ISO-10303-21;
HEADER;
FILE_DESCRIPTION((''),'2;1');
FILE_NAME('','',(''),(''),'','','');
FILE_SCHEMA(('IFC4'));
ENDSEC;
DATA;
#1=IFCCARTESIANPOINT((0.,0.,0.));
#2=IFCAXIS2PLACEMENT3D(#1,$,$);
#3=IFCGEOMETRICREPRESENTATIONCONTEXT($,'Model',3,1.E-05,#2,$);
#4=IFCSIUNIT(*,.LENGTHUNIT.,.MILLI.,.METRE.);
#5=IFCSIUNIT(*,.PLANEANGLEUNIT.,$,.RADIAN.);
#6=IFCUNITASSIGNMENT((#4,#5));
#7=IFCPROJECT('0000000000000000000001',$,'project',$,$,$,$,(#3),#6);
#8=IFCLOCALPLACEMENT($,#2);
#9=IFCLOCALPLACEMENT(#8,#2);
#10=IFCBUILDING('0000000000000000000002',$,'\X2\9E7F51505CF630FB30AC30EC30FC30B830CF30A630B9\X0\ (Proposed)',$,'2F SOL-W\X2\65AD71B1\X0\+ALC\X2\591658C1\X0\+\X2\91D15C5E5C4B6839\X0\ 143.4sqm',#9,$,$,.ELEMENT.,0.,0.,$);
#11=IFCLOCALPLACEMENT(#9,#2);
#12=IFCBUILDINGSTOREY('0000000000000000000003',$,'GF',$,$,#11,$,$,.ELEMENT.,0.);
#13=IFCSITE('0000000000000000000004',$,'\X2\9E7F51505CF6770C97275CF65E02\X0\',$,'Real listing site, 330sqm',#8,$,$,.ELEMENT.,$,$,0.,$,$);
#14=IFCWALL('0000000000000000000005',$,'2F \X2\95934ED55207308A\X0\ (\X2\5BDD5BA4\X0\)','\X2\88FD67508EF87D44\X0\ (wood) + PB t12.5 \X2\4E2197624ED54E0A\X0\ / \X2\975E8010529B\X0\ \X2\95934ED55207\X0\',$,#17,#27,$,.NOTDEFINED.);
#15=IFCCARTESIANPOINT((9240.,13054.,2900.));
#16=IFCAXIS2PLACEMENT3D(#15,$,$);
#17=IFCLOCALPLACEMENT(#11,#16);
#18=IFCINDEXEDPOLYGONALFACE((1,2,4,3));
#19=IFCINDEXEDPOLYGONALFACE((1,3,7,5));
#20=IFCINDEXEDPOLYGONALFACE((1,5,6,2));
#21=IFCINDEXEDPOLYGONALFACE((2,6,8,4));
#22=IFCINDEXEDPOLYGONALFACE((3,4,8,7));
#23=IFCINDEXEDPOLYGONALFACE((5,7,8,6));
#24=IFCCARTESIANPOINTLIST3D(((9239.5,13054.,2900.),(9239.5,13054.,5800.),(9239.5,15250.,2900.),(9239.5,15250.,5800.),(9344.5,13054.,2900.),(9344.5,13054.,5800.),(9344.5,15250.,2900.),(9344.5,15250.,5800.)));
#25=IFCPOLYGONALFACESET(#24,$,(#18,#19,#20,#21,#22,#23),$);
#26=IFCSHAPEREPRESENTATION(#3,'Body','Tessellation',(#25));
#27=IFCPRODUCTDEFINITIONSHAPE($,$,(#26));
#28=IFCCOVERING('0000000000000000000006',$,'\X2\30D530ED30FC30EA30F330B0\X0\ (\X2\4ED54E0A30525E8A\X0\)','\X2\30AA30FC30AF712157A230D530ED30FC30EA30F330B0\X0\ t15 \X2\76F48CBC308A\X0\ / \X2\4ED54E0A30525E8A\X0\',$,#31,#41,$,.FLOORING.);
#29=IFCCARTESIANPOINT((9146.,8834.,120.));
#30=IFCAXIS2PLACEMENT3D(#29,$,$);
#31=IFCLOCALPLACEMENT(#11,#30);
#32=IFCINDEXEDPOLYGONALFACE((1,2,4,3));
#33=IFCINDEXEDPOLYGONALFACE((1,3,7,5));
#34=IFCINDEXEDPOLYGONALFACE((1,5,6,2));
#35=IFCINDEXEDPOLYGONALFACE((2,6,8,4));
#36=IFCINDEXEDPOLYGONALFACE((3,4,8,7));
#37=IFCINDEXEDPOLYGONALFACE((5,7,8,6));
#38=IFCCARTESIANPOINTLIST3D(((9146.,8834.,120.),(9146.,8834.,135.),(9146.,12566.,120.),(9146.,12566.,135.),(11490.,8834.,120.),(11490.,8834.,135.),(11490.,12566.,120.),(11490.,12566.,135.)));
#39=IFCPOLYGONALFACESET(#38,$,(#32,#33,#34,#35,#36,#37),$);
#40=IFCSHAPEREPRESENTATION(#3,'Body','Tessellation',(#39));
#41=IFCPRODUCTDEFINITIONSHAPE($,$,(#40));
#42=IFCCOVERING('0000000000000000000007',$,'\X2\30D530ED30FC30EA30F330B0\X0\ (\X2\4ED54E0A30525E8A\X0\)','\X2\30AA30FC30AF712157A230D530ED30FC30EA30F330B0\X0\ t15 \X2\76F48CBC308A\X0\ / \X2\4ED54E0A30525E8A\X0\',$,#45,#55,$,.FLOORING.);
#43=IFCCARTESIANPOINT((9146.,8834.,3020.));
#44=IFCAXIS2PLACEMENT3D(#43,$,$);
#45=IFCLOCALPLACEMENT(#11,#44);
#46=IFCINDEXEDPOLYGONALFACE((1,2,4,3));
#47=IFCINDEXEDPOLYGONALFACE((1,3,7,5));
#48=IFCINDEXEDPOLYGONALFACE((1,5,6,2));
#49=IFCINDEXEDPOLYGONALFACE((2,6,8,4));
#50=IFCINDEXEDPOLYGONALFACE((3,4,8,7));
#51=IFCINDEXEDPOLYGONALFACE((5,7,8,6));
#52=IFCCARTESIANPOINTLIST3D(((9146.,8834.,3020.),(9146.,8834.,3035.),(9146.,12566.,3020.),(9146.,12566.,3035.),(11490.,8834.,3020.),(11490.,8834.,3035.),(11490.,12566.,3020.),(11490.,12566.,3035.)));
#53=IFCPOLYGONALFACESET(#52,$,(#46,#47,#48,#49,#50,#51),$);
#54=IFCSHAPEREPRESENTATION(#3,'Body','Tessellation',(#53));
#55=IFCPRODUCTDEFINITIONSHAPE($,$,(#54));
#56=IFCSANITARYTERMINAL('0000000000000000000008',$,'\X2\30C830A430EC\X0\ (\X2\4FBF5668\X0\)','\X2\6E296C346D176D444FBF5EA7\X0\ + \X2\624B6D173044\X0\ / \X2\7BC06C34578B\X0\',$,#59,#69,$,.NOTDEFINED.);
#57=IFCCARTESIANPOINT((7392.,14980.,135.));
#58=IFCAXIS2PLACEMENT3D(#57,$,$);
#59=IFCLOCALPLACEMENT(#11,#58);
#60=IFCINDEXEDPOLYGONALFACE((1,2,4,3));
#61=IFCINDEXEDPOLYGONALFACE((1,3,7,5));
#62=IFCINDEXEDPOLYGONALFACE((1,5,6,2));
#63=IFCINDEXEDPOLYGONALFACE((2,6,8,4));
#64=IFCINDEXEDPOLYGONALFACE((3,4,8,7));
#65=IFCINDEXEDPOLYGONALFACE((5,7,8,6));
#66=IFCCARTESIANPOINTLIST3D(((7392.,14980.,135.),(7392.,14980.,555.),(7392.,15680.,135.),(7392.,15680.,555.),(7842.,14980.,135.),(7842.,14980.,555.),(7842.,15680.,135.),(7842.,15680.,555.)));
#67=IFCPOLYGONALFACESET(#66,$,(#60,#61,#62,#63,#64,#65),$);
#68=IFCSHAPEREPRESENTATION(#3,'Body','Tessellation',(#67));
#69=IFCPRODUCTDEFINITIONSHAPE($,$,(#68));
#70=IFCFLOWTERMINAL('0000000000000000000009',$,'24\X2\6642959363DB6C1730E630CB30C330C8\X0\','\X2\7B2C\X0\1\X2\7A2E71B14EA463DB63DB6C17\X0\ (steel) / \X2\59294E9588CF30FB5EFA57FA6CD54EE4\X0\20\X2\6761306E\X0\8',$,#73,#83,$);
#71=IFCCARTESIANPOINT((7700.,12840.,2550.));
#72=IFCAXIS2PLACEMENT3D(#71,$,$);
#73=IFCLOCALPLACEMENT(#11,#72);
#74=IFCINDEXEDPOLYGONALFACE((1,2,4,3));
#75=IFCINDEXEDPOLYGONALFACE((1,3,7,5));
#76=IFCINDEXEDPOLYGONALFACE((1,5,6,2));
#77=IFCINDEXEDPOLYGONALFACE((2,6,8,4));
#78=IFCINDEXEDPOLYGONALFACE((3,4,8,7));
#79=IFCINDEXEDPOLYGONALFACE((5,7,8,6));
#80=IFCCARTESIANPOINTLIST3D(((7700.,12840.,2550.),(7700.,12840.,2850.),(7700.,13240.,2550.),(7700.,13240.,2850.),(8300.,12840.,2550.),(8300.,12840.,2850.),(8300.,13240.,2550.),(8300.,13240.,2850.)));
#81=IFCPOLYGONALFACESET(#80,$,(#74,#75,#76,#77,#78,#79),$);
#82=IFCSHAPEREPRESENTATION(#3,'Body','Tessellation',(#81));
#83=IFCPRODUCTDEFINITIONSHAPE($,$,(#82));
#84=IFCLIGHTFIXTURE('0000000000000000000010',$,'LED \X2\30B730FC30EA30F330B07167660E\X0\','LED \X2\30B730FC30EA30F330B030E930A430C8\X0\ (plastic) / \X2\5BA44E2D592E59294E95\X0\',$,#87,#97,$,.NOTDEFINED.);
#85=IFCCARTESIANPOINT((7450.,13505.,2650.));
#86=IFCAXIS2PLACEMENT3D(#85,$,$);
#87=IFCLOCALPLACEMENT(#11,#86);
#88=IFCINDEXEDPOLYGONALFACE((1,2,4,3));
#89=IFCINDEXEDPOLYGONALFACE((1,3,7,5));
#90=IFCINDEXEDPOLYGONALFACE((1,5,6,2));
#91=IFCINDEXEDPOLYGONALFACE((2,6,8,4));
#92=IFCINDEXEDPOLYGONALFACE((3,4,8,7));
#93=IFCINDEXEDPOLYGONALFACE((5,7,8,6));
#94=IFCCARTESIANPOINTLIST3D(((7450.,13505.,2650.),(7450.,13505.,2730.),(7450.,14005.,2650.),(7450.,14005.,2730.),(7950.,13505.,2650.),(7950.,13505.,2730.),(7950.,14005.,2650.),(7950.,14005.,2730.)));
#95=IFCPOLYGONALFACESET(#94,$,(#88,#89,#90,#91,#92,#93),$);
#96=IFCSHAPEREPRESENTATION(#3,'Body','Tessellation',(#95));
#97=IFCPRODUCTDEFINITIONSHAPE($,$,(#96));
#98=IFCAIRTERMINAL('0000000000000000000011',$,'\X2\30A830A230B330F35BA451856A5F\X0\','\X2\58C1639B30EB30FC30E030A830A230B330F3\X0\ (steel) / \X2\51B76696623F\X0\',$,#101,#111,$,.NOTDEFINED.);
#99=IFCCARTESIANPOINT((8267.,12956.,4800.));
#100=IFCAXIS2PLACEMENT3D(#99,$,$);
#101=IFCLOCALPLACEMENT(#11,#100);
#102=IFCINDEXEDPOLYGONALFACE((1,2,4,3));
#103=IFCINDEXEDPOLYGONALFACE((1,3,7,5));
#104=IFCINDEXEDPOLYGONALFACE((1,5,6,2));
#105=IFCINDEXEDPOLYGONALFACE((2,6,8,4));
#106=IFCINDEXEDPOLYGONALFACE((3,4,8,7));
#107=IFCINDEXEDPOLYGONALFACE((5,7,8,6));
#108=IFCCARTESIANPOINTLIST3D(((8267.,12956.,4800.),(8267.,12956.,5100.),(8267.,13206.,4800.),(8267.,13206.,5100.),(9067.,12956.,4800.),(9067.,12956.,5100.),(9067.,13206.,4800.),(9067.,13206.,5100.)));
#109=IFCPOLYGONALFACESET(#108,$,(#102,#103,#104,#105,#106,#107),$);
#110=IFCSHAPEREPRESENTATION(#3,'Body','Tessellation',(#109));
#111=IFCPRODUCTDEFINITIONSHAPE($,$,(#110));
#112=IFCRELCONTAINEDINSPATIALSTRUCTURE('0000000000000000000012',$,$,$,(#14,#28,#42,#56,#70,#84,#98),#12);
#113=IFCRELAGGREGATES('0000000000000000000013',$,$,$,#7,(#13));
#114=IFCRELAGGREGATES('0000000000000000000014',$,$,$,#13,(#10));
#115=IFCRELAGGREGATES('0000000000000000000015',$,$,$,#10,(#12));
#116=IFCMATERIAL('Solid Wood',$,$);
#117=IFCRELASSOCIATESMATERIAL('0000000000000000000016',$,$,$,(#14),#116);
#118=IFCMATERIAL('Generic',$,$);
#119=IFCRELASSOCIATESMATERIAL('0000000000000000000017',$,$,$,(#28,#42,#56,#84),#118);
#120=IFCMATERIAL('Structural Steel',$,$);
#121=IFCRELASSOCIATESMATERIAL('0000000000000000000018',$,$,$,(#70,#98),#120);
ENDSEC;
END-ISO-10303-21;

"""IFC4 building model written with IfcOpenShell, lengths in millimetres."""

from ifc_helpers import new_model, si_unit, frame, frame_2d, origin, place, context, project, spatial, rectangle, extrude, material, element, save


model = new_model("IFC4")

# Units and contexts
model_context = context("Model", 3, precision=1e-05, world=origin())
ifc_project = project(units=[si_unit("LENGTHUNIT", "METRE", prefix="MILLI"), si_unit("PLANEANGLEUNIT", "RADIAN")], contexts=[model_context])

# Site, building, storey
site_placement = place(None, origin())
site = spatial("IfcSite", under=ifc_project, at=site_placement, Name="鹿児島県霧島市", ObjectType="Real listing site, 330sqm", CompositionType="ELEMENT", RefElevation=0.0)
building_placement = place(site_placement, origin())
building = spatial("IfcBuilding", under=site, at=building_placement, Name="鹿児島・ガレージハウス (Proposed)", ObjectType="2F SOL-W断熱+ALC外壁+金属屋根 143.4sqm", CompositionType="ELEMENT", ElevationOfRefHeight=0.0, ElevationOfTerrain=0.0)
storey_placement = place(building_placement, origin())
storey = spatial("IfcBuildingStorey", under=building, at=storey_placement, Name="GF", CompositionType="ELEMENT", Elevation=0.0)

# Shared definitions
ifc_material_1 = material(Name="Solid Wood")

# Wall
wall_1_placement = place(storey_placement, frame((9240.0, 13054.0, 2900.0)))
element("IfcWall", 1, at=wall_1_placement, inside=storey, material=ifc_material_1, Name="2F 間仕切り (寝室)", Description="製材軸組 (wood) + PB t12.5 両面仕上 / 非耐力 間仕切", PredefinedType="NOTDEFINED", context=model_context, shape_type="SweptSolid", body=[
    extrude(rectangle(XDim=105.0, YDim=2196.0, at=frame_2d((52.0, 1098.0))), frame((9240.0, 13054.0, 2900.0)), (0.0, 0.0, 1.0), 2900.0),
])

# Coverings
ifc_material_2 = material(Name="Generic")
covering_1_placement = place(storey_placement, frame((9146.0, 8834.0, 120.0)))
element("IfcCovering", 2, at=covering_1_placement, inside=storey, material=ifc_material_2, Name="フローリング (仕上げ床)", Description="オーク無垢フローリング t15 直貼り / 仕上げ床", PredefinedType="FLOORING", context=model_context, shape_type="SweptSolid", body=[
    extrude(rectangle(XDim=2344.0, YDim=3732.0, at=frame_2d((1172.0, 1866.0))), frame((9146.0, 8834.0, 120.0)), (0.0, 0.0, 1.0), 15.0),
])
covering_2_placement = place(storey_placement, frame((9146.0, 8834.0, 3020.0)))
element("IfcCovering", 3, at=covering_2_placement, inside=storey, material=ifc_material_2, Name="フローリング (仕上げ床)", Description="オーク無垢フローリング t15 直貼り / 仕上げ床", PredefinedType="FLOORING", context=model_context, shape_type="SweptSolid", body=[
    extrude(rectangle(XDim=2344.0, YDim=3732.0, at=frame_2d((1172.0, 1866.0))), frame((9146.0, 8834.0, 3020.0)), (0.0, 0.0, 1.0), 15.0),
])

# Sanitary terminal
sanitary_terminal_placement = place(storey_placement, frame((7392.0, 14980.0, 135.0)))
element("IfcSanitaryTerminal", 4, at=sanitary_terminal_placement, inside=storey, material=ifc_material_2, Name="トイレ (便器)", Description="温水洗浄便座 + 手洗い / 節水型", PredefinedType="NOTDEFINED", context=model_context, shape_type="SweptSolid", body=[
    extrude(rectangle(XDim=450.0, YDim=700.0, at=frame_2d((225.0, 350.0))), frame((7392.0, 14980.0, 135.0)), (0.0, 0.0, 1.0), 420.0),
])

# Flow terminal
ifc_material_3 = material(Name="Structural Steel")
flow_terminal_placement = place(storey_placement, frame((7700.0, 12840.0, 2550.0)))
element("IfcFlowTerminal", 5, at=flow_terminal_placement, inside=storey, material=ifc_material_3, Name="24時間換気ユニット", Description="第1種熱交換換気 (steel) / 天井裏・建基法令20条の8", context=model_context, shape_type="SweptSolid", body=[
    extrude(rectangle(XDim=600.0, YDim=400.0, at=frame_2d((300.0, 200.0))), frame((7700.0, 12840.0, 2550.0)), (0.0, 0.0, 1.0), 300.0),
])

# Light fixture
light_fixture_placement = place(storey_placement, frame((7450.0, 13505.0, 2650.0)))
element("IfcLightFixture", 6, at=light_fixture_placement, inside=storey, material=ifc_material_2, Name="LED シーリング照明", Description="LED シーリングライト (plastic) / 室中央天井", PredefinedType="NOTDEFINED", context=model_context, shape_type="SweptSolid", body=[
    extrude(rectangle(XDim=500.0, YDim=500.0, at=frame_2d((250.0, 250.0))), frame((7450.0, 13505.0, 2650.0)), (0.0, 0.0, 1.0), 80.0),
])

# Air terminal
air_terminal_placement = place(storey_placement, frame((8267.0, 12956.0, 4800.0)))
element("IfcAirTerminal", 7, at=air_terminal_placement, inside=storey, material=ifc_material_3, Name="エアコン室内機", Description="壁掛ルームエアコン (steel) / 冷暖房", PredefinedType="NOTDEFINED", context=model_context, shape_type="SweptSolid", body=[
    extrude(rectangle(XDim=800.0, YDim=250.0, at=frame_2d((400.0, 125.0))), frame((8267.0, 12956.0, 4800.0)), (0.0, 0.0, 1.0), 300.0),
])

save(model, "model.ifc")
